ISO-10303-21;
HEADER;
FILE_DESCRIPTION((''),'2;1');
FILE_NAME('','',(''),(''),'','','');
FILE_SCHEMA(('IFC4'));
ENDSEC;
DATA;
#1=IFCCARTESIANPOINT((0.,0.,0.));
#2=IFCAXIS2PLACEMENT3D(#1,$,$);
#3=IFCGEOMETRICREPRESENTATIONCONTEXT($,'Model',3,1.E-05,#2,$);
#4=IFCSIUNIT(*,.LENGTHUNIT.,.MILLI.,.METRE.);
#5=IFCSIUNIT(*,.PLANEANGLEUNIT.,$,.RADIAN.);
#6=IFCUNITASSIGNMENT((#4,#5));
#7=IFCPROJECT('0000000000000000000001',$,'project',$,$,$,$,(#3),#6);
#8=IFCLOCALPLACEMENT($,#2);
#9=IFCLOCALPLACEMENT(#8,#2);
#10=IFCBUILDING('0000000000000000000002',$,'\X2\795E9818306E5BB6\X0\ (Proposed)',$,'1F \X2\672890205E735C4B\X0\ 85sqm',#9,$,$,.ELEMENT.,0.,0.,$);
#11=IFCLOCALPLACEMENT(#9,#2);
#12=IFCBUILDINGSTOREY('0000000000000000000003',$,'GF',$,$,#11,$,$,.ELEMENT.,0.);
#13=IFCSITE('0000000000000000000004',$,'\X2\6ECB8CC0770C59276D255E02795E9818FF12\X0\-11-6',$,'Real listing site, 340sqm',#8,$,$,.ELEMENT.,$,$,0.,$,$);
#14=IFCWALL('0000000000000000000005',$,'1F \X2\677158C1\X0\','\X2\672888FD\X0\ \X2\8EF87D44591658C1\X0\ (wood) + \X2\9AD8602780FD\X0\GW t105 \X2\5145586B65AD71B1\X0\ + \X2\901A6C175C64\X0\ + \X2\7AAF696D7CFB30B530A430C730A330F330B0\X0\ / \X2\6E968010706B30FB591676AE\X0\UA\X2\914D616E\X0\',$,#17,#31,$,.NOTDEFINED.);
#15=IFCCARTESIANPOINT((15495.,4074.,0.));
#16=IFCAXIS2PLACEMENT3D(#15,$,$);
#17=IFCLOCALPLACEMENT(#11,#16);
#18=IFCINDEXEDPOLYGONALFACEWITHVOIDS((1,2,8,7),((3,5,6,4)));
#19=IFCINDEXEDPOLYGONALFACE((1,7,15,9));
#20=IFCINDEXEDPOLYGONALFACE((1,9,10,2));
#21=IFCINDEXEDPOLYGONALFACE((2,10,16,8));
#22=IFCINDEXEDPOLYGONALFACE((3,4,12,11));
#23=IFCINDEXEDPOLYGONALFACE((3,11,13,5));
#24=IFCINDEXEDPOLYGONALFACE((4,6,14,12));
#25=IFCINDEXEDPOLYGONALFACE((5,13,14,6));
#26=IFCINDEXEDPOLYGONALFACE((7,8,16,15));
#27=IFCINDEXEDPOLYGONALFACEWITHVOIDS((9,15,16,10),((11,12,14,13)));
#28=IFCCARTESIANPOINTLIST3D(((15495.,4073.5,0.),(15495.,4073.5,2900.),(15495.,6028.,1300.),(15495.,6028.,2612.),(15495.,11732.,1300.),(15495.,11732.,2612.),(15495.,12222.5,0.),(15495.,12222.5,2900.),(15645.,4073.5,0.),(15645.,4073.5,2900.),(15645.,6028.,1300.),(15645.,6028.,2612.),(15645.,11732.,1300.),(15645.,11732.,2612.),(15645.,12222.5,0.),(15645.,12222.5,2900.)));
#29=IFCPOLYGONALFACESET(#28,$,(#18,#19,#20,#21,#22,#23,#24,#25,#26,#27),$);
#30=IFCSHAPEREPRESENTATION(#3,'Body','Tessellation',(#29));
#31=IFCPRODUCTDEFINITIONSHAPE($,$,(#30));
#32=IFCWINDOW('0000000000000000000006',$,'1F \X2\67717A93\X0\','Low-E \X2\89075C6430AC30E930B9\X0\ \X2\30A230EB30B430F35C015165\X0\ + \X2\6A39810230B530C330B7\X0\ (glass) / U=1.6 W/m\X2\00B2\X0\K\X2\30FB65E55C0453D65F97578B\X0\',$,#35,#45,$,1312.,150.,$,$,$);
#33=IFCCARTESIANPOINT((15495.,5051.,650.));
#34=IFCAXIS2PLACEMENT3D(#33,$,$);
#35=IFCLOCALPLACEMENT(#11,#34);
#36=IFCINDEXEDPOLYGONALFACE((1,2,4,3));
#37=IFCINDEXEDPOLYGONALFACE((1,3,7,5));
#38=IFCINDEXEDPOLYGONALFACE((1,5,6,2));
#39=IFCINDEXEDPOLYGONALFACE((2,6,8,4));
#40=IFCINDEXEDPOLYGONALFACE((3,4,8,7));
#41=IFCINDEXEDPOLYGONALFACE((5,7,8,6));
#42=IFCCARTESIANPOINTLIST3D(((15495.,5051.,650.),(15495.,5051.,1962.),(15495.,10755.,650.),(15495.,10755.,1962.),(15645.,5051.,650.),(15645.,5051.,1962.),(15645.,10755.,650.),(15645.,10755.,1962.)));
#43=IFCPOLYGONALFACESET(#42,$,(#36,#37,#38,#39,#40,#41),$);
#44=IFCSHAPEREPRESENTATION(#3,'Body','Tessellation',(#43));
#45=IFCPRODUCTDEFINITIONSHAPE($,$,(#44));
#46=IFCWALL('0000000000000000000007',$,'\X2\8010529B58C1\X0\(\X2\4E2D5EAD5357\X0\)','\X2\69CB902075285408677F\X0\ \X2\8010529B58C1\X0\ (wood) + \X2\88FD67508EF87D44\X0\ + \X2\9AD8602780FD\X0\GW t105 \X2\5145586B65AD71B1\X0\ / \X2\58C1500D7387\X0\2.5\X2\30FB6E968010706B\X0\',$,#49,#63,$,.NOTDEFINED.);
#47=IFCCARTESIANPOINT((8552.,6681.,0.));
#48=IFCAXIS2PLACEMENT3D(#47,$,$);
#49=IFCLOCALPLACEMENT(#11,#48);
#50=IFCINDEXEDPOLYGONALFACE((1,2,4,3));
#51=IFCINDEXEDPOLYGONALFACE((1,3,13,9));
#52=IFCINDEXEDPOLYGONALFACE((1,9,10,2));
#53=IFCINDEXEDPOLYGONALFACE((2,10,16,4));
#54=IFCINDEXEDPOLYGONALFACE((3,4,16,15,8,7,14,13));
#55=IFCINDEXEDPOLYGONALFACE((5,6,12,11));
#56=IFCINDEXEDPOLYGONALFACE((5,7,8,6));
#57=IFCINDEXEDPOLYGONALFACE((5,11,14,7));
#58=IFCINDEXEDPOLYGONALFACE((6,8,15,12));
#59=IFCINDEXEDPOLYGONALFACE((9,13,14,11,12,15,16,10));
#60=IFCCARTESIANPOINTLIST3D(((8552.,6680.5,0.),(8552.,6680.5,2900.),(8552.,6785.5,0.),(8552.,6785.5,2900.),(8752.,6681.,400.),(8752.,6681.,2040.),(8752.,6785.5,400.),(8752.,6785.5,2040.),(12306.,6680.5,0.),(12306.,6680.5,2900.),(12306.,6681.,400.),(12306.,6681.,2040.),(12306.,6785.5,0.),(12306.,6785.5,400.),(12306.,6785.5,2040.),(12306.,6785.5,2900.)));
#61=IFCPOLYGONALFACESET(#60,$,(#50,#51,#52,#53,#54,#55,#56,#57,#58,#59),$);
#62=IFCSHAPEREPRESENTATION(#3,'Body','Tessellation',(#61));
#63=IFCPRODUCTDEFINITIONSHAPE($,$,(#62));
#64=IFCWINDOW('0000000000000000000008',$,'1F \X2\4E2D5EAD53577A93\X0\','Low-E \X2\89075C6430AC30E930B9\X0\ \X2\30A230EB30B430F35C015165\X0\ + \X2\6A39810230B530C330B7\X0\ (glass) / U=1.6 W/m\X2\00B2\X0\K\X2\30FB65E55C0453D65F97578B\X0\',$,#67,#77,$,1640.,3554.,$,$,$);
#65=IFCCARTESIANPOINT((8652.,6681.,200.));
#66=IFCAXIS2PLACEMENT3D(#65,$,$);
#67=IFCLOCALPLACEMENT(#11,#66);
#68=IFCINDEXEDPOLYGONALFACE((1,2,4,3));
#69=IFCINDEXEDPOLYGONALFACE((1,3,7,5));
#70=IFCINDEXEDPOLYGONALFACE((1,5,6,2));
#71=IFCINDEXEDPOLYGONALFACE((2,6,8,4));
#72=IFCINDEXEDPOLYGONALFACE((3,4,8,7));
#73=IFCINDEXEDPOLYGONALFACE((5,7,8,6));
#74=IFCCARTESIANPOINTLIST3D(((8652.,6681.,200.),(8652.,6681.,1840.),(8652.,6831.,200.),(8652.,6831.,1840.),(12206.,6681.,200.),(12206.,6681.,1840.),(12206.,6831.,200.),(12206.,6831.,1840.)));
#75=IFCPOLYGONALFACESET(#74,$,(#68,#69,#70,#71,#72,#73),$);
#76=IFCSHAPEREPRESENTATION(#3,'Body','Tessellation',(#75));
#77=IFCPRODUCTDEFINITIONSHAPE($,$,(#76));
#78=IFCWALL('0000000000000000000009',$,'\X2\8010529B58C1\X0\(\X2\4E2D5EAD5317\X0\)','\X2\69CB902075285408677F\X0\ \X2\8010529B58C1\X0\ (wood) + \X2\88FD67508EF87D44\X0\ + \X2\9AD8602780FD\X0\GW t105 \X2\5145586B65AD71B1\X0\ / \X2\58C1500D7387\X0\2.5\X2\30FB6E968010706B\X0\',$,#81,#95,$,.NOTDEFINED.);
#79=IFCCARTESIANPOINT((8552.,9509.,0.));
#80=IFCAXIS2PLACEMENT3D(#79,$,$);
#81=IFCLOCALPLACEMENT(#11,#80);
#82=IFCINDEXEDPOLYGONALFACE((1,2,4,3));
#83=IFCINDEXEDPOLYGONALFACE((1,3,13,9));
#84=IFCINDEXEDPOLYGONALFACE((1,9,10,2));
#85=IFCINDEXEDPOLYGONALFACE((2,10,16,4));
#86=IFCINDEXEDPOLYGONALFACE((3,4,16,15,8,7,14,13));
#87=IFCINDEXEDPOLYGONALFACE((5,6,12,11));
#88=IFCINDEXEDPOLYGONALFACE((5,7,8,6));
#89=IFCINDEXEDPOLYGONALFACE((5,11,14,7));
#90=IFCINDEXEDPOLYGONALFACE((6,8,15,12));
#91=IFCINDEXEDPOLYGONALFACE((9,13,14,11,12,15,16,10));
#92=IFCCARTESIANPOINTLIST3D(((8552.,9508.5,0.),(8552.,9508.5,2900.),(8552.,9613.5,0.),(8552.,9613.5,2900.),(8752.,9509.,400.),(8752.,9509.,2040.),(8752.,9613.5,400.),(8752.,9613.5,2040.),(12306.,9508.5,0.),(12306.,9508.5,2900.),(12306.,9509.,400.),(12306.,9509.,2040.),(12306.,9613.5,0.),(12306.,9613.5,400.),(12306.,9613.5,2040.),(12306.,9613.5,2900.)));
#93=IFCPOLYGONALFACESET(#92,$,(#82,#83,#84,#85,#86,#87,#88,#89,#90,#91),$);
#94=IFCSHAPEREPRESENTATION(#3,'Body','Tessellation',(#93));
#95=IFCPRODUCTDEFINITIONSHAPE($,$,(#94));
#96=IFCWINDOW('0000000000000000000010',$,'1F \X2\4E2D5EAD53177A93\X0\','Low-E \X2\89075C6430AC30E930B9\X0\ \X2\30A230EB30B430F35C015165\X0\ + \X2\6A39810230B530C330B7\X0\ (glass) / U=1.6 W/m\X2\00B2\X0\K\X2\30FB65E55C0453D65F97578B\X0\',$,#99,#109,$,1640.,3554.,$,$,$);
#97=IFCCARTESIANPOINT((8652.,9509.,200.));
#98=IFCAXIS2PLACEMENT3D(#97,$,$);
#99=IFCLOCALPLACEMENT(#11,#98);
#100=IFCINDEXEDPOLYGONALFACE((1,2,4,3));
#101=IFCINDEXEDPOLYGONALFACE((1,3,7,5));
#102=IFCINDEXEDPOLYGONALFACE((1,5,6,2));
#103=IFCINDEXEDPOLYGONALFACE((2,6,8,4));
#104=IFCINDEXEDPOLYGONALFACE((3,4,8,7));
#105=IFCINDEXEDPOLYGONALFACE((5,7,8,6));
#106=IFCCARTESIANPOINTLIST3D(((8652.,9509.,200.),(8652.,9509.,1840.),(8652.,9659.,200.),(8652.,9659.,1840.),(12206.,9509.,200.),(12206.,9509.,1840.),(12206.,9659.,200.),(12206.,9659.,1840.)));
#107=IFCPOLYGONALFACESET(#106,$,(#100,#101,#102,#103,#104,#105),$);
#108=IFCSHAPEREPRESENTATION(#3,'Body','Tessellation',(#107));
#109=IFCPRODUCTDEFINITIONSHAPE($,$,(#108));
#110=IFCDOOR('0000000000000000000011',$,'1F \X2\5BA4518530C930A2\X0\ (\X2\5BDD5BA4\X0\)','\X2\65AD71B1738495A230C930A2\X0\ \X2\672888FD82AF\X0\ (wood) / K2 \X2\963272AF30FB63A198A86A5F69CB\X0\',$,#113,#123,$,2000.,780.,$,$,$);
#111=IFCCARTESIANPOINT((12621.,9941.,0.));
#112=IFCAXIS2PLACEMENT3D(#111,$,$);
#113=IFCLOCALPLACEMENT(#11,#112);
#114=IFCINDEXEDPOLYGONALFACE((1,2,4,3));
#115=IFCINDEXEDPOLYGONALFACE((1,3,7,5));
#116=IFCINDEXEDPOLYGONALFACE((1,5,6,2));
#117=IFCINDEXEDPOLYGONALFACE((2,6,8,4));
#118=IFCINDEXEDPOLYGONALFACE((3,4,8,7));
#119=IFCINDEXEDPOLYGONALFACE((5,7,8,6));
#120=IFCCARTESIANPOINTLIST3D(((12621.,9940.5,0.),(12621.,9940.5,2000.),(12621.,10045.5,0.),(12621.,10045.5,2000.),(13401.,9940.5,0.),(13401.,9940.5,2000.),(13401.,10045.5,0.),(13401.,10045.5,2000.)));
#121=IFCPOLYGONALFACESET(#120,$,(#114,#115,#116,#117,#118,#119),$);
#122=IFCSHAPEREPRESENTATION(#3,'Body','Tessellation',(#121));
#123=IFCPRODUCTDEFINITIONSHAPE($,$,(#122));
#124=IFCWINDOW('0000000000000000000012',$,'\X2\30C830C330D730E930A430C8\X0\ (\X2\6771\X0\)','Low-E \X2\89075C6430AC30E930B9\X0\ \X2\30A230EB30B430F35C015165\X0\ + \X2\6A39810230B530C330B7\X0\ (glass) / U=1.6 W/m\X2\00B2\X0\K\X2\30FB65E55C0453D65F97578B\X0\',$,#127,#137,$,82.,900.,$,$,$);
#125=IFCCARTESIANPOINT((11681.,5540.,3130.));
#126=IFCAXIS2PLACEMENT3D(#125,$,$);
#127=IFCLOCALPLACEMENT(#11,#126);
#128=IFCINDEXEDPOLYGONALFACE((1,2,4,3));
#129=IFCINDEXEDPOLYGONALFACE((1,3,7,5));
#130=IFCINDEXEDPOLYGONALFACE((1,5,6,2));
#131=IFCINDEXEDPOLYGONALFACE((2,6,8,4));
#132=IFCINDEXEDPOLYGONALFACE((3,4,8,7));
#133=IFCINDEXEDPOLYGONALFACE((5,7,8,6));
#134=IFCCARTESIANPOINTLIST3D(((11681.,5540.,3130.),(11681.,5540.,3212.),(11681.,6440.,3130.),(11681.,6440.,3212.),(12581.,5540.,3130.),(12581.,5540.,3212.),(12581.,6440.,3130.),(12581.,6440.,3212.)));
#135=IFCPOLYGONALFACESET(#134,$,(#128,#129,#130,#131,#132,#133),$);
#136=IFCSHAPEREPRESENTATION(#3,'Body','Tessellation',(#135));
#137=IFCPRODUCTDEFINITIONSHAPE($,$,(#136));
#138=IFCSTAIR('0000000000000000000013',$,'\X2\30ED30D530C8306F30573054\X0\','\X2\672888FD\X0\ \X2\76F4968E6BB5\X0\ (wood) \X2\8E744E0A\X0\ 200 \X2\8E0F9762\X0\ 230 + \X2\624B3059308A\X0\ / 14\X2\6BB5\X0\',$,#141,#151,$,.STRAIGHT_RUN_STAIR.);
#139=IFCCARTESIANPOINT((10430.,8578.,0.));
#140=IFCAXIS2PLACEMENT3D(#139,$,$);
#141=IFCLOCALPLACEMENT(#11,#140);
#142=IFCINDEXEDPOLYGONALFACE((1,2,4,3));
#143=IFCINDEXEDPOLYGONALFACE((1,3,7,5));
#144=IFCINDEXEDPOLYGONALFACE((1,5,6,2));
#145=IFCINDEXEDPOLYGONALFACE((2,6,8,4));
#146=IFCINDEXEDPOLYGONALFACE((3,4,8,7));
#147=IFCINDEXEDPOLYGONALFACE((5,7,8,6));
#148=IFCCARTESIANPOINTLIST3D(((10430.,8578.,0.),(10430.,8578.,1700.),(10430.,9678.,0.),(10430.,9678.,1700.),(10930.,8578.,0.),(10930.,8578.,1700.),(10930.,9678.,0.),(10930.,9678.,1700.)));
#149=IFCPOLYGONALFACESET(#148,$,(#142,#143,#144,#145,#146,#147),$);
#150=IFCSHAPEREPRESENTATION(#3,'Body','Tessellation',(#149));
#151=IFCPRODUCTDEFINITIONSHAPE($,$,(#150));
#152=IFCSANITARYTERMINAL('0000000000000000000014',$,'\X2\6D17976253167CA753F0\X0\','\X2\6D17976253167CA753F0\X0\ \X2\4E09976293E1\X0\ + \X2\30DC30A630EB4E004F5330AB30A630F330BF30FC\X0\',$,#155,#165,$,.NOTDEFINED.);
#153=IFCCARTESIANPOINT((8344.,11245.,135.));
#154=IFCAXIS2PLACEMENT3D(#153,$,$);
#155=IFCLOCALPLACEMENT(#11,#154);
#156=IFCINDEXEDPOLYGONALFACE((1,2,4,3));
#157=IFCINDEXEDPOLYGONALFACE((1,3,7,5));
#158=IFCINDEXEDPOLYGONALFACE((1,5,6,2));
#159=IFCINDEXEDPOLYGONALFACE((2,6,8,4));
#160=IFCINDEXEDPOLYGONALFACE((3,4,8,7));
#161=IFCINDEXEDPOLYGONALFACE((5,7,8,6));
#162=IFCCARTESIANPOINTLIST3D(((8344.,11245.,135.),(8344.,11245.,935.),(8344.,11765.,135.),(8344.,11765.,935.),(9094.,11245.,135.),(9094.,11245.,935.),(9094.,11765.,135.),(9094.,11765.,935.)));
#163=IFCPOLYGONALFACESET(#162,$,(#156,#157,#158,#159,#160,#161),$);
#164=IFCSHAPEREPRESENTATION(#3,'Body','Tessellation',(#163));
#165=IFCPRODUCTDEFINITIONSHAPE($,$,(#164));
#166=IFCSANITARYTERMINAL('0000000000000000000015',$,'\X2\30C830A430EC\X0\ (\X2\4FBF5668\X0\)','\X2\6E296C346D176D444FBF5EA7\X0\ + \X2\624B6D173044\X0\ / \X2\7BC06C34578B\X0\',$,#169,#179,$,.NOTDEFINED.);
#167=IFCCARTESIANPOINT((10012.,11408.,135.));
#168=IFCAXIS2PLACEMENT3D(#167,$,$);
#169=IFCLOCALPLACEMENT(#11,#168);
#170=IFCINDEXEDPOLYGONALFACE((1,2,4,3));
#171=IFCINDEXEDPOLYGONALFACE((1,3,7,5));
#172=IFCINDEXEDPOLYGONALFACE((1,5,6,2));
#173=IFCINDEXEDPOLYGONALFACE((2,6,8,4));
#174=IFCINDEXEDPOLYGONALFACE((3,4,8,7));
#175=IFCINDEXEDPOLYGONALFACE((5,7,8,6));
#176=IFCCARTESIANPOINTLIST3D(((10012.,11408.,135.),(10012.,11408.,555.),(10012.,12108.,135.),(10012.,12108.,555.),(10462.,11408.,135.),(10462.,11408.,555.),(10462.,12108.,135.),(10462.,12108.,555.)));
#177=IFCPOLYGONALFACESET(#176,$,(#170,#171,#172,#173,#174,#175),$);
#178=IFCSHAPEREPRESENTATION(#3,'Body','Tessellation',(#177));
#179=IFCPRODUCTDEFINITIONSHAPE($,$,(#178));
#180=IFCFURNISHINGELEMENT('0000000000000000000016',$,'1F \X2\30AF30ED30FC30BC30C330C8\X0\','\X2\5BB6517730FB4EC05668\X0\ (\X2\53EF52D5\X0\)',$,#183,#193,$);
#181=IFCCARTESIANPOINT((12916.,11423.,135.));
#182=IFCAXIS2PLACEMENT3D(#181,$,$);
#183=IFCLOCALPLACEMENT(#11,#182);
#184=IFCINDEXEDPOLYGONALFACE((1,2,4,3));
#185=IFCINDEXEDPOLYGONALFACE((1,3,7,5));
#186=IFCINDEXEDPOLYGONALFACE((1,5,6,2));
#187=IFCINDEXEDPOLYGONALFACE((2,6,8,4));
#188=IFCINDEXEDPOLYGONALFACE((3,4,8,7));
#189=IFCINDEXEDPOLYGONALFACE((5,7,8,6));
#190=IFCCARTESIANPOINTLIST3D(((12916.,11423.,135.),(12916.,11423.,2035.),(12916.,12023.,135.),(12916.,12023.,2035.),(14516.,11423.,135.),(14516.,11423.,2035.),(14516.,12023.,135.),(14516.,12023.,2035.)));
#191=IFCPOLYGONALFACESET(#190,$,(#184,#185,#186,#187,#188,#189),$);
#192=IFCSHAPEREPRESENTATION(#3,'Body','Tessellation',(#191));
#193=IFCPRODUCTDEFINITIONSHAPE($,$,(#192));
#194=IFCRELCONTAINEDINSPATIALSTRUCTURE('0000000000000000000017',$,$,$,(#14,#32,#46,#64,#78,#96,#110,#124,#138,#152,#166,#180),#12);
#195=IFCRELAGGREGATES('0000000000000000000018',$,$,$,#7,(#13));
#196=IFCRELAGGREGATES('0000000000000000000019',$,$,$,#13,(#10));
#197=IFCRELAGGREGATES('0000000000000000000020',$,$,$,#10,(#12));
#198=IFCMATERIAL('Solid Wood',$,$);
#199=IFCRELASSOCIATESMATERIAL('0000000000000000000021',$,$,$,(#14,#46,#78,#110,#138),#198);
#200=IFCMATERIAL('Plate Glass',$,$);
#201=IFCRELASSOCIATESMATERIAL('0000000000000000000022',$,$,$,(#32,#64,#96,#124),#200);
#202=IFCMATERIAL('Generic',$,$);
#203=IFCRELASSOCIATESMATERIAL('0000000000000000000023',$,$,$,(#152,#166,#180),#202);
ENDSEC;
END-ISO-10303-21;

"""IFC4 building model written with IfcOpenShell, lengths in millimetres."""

from ifc_helpers import new_model, si_unit, frame, frame_2d, origin, place, context, project, spatial, rectangle, extrude, material, element, fill, save


model = new_model("IFC4")

# Units and contexts
model_context = context("Model", 3, precision=1e-05, world=origin())
ifc_project = project(units=[si_unit("LENGTHUNIT", "METRE", prefix="MILLI"), si_unit("PLANEANGLEUNIT", "RADIAN")], contexts=[model_context])

# Site, building, storey
site_placement = place(None, origin())
site = spatial("IfcSite", under=ifc_project, at=site_placement, Name="滋賀県大津市神領２-11-6", ObjectType="Real listing site, 340sqm", CompositionType="ELEMENT", RefElevation=0.0)
building_placement = place(site_placement, origin())
building = spatial("IfcBuilding", under=site, at=building_placement, Name="神領の家 (Proposed)", ObjectType="1F 木造平屋 85sqm", CompositionType="ELEMENT", ElevationOfRefHeight=0.0, ElevationOfTerrain=0.0)
storey_placement = place(building_placement, origin())
storey = spatial("IfcBuildingStorey", under=building, at=storey_placement, Name="GF", CompositionType="ELEMENT", Elevation=0.0)

# Shared definitions
ifc_material_1 = material(Name="Solid Wood")

# Walls, openings, windows
wall_1_placement = place(storey_placement, frame((15495.0, 4074.0, 0.0)))
wall_1 = element("IfcWall", 1, at=wall_1_placement, inside=storey, material=ifc_material_1, Name="1F 東壁", Description="木製 軸組外壁 (wood) + 高性能GW t105 充填断熱 + 通気層 + 窯業系サイディング / 準耐火・外皮UA配慮", PredefinedType="NOTDEFINED", context=model_context, shape_type="SweptSolid", body=[
    extrude(rectangle(XDim=150.0, YDim=8149.0, at=frame_2d((75.0, 4074.0))), frame((15495.0, 4074.0, 0.0)), (0.0, 0.0, 1.0), 2900.0),
])
opening_1_placement = place(storey_placement, frame((15495.0, 5051.0, 650.0)))
opening_1 = element("IfcOpeningElement", 2, at=opening_1_placement, cuts=wall_1, PredefinedType="NOTDEFINED", context=model_context, shape_type="SweptSolid", body=[
    extrude(rectangle(XDim=150.0, YDim=5704.0, at=frame_2d((75.0, 2852.0))), frame((15495.0, 5051.0, 650.0)), (0.0, 0.0, 1.0), 1312.0),
])
ifc_material_2 = material(Name="Plate Glass")
window_1_placement = place(storey_placement, frame((15495.0, 5051.0, 650.0)))
window_1 = element("IfcWindow", 3, at=window_1_placement, inside=storey, material=ifc_material_2, Name="1F 東窓", Description="Low-E 複層ガラス アルゴン封入 + 樹脂サッシ (glass) / U=1.6 W/m²K・日射取得型", OverallHeight=1312.0, OverallWidth=150.0, context=model_context, shape_type="SweptSolid", body=[
    extrude(rectangle(XDim=150.0, YDim=5704.0, at=frame_2d((75.0, 2852.0))), frame((15495.0, 5051.0, 650.0)), (0.0, 0.0, 1.0), 1312.0),
])
fill(opening_1, window_1)
wall_2_placement = place(storey_placement, frame((8552.0, 6681.0, 0.0)))
wall_2 = element("IfcWall", 4, at=wall_2_placement, inside=storey, material=ifc_material_1, Name="耐力壁(中庭南)", Description="構造用合板 耐力壁 (wood) + 製材軸組 + 高性能GW t105 充填断熱 / 壁倍率2.5・準耐火", PredefinedType="NOTDEFINED", context=model_context, shape_type="SweptSolid", body=[
    extrude(rectangle(XDim=3754.0, YDim=105.0, at=frame_2d((1877.0, 52.0))), frame((8552.0, 6681.0, 0.0)), (0.0, 0.0, 1.0), 2900.0),
])
opening_2_placement = place(storey_placement, frame((8652.0, 6681.0, 200.0)))
opening_2 = element("IfcOpeningElement", 5, at=opening_2_placement, cuts=wall_2, PredefinedType="NOTDEFINED", context=model_context, shape_type="SweptSolid", body=[
    extrude(rectangle(XDim=3554.0, YDim=150.0, at=frame_2d((1777.0, 75.0))), frame((8652.0, 6681.0, 200.0)), (0.0, 0.0, 1.0), 1640.0),
])
window_2_placement = place(storey_placement, frame((8652.0, 6681.0, 200.0)))
window_2 = element("IfcWindow", 6, at=window_2_placement, inside=storey, material=ifc_material_2, Name="1F 中庭南窓", Description="Low-E 複層ガラス アルゴン封入 + 樹脂サッシ (glass) / U=1.6 W/m²K・日射取得型", OverallHeight=1640.0, OverallWidth=3554.0, context=model_context, shape_type="SweptSolid", body=[
    extrude(rectangle(XDim=3554.0, YDim=150.0, at=frame_2d((1777.0, 75.0))), frame((8652.0, 6681.0, 200.0)), (0.0, 0.0, 1.0), 1640.0),
])
fill(opening_2, window_2)
wall_3_placement = place(storey_placement, frame((8552.0, 9509.0, 0.0)))
wall_3 = element("IfcWall", 7, at=wall_3_placement, inside=storey, material=ifc_material_1, Name="耐力壁(中庭北)", Description="構造用合板 耐力壁 (wood) + 製材軸組 + 高性能GW t105 充填断熱 / 壁倍率2.5・準耐火", PredefinedType="NOTDEFINED", context=model_context, shape_type="SweptSolid", body=[
    extrude(rectangle(XDim=3754.0, YDim=105.0, at=frame_2d((1877.0, 52.0))), frame((8552.0, 9509.0, 0.0)), (0.0, 0.0, 1.0), 2900.0),
])
opening_3_placement = place(storey_placement, frame((8652.0, 9509.0, 200.0)))
opening_3 = element("IfcOpeningElement", 8, at=opening_3_placement, cuts=wall_3, PredefinedType="NOTDEFINED", context=model_context, shape_type="SweptSolid", body=[
    extrude(rectangle(XDim=3554.0, YDim=150.0, at=frame_2d((1777.0, 75.0))), frame((8652.0, 9509.0, 200.0)), (0.0, 0.0, 1.0), 1640.0),
])
window_3_placement = place(storey_placement, frame((8652.0, 9509.0, 200.0)))
window_3 = element("IfcWindow", 9, at=window_3_placement, inside=storey, material=ifc_material_2, Name="1F 中庭北窓", Description="Low-E 複層ガラス アルゴン封入 + 樹脂サッシ (glass) / U=1.6 W/m²K・日射取得型", OverallHeight=1640.0, OverallWidth=3554.0, context=model_context, shape_type="SweptSolid", body=[
    extrude(rectangle(XDim=3554.0, YDim=150.0, at=frame_2d((1777.0, 75.0))), frame((8652.0, 9509.0, 200.0)), (0.0, 0.0, 1.0), 1640.0),
])
fill(opening_3, window_3)

# Door
door_placement = place(storey_placement, frame((12621.0, 9941.0, 0.0)))
element("IfcDoor", 10, at=door_placement, inside=storey, material=ifc_material_1, Name="1F 室内ドア (寝室)", Description="断熱玄関ドア 木製芯 (wood) / K2 防犯・採風機構", OverallHeight=2000.0, OverallWidth=780.0, context=model_context, shape_type="SweptSolid", body=[
    extrude(rectangle(XDim=780.0, YDim=105.0, at=frame_2d((390.0, 52.0))), frame((12621.0, 9941.0, 0.0)), (0.0, 0.0, 1.0), 2000.0),
])

# Window
window_4_placement = place(storey_placement, frame((11681.0, 5540.0, 3130.0)))
element("IfcWindow", 11, at=window_4_placement, inside=storey, material=ifc_material_2, Name="トップライト (東)", Description="Low-E 複層ガラス アルゴン封入 + 樹脂サッシ (glass) / U=1.6 W/m²K・日射取得型", OverallHeight=82.0, OverallWidth=900.0, context=model_context, shape_type="SweptSolid", body=[
    extrude(rectangle(XDim=900.0, YDim=900.0, at=frame_2d((450.0, 450.0))), frame((11681.0, 5540.0, 3130.0)), (0.0, 0.0, 1.0), 82.0),
])

# Stair
stair_placement = place(storey_placement, frame((10430.0, 8578.0, 0.0)))
element("IfcStair", 12, at=stair_placement, inside=storey, material=ifc_material_1, Name="ロフトはしご", Description="木製 直階段 (wood) 蹴上 200 踏面 230 + 手すり / 14段", PredefinedType="STRAIGHT_RUN_STAIR", context=model_context, shape_type="SweptSolid", body=[
    extrude(rectangle(XDim=500.0, YDim=1100.0, at=frame_2d((250.0, 550.0))), frame((10430.0, 8578.0, 0.0)), (0.0, 0.0, 1.0), 1700.0),
])

# Shared definitions
ifc_material_3 = material(Name="Generic")

# Sanitary terminals
sanitary_terminal_1_placement = place(storey_placement, frame((8344.0, 11245.0, 135.0)))
element("IfcSanitaryTerminal", 13, at=sanitary_terminal_1_placement, inside=storey, material=ifc_material_3, Name="洗面化粧台", Description="洗面化粧台 三面鏡 + ボウル一体カウンター", PredefinedType="NOTDEFINED", context=model_context, shape_type="SweptSolid", body=[
    extrude(rectangle(XDim=750.0, YDim=520.0, at=frame_2d((375.0, 260.0))), frame((8344.0, 11245.0, 135.0)), (0.0, 0.0, 1.0), 800.0),
])
sanitary_terminal_2_placement = place(storey_placement, frame((10012.0, 11408.0, 135.0)))
element("IfcSanitaryTerminal", 14, at=sanitary_terminal_2_placement, inside=storey, material=ifc_material_3, Name="トイレ (便器)", Description="温水洗浄便座 + 手洗い / 節水型", PredefinedType="NOTDEFINED", context=model_context, shape_type="SweptSolid", body=[
    extrude(rectangle(XDim=450.0, YDim=700.0, at=frame_2d((225.0, 350.0))), frame((10012.0, 11408.0, 135.0)), (0.0, 0.0, 1.0), 420.0),
])

# Furnishing element
furnishing_1_placement = place(storey_placement, frame((12916.0, 11423.0, 135.0)))
element("IfcFurnishingElement", 15, at=furnishing_1_placement, inside=storey, material=ifc_material_3, Name="1F クローゼット", Description="家具・什器 (可動)", context=model_context, shape_type="SweptSolid", body=[
    extrude(rectangle(XDim=1600.0, YDim=600.0, at=frame_2d((800.0, 300.0))), frame((12916.0, 11423.0, 135.0)), (0.0, 0.0, 1.0), 1900.0),
])

save(model, "model.ifc")
